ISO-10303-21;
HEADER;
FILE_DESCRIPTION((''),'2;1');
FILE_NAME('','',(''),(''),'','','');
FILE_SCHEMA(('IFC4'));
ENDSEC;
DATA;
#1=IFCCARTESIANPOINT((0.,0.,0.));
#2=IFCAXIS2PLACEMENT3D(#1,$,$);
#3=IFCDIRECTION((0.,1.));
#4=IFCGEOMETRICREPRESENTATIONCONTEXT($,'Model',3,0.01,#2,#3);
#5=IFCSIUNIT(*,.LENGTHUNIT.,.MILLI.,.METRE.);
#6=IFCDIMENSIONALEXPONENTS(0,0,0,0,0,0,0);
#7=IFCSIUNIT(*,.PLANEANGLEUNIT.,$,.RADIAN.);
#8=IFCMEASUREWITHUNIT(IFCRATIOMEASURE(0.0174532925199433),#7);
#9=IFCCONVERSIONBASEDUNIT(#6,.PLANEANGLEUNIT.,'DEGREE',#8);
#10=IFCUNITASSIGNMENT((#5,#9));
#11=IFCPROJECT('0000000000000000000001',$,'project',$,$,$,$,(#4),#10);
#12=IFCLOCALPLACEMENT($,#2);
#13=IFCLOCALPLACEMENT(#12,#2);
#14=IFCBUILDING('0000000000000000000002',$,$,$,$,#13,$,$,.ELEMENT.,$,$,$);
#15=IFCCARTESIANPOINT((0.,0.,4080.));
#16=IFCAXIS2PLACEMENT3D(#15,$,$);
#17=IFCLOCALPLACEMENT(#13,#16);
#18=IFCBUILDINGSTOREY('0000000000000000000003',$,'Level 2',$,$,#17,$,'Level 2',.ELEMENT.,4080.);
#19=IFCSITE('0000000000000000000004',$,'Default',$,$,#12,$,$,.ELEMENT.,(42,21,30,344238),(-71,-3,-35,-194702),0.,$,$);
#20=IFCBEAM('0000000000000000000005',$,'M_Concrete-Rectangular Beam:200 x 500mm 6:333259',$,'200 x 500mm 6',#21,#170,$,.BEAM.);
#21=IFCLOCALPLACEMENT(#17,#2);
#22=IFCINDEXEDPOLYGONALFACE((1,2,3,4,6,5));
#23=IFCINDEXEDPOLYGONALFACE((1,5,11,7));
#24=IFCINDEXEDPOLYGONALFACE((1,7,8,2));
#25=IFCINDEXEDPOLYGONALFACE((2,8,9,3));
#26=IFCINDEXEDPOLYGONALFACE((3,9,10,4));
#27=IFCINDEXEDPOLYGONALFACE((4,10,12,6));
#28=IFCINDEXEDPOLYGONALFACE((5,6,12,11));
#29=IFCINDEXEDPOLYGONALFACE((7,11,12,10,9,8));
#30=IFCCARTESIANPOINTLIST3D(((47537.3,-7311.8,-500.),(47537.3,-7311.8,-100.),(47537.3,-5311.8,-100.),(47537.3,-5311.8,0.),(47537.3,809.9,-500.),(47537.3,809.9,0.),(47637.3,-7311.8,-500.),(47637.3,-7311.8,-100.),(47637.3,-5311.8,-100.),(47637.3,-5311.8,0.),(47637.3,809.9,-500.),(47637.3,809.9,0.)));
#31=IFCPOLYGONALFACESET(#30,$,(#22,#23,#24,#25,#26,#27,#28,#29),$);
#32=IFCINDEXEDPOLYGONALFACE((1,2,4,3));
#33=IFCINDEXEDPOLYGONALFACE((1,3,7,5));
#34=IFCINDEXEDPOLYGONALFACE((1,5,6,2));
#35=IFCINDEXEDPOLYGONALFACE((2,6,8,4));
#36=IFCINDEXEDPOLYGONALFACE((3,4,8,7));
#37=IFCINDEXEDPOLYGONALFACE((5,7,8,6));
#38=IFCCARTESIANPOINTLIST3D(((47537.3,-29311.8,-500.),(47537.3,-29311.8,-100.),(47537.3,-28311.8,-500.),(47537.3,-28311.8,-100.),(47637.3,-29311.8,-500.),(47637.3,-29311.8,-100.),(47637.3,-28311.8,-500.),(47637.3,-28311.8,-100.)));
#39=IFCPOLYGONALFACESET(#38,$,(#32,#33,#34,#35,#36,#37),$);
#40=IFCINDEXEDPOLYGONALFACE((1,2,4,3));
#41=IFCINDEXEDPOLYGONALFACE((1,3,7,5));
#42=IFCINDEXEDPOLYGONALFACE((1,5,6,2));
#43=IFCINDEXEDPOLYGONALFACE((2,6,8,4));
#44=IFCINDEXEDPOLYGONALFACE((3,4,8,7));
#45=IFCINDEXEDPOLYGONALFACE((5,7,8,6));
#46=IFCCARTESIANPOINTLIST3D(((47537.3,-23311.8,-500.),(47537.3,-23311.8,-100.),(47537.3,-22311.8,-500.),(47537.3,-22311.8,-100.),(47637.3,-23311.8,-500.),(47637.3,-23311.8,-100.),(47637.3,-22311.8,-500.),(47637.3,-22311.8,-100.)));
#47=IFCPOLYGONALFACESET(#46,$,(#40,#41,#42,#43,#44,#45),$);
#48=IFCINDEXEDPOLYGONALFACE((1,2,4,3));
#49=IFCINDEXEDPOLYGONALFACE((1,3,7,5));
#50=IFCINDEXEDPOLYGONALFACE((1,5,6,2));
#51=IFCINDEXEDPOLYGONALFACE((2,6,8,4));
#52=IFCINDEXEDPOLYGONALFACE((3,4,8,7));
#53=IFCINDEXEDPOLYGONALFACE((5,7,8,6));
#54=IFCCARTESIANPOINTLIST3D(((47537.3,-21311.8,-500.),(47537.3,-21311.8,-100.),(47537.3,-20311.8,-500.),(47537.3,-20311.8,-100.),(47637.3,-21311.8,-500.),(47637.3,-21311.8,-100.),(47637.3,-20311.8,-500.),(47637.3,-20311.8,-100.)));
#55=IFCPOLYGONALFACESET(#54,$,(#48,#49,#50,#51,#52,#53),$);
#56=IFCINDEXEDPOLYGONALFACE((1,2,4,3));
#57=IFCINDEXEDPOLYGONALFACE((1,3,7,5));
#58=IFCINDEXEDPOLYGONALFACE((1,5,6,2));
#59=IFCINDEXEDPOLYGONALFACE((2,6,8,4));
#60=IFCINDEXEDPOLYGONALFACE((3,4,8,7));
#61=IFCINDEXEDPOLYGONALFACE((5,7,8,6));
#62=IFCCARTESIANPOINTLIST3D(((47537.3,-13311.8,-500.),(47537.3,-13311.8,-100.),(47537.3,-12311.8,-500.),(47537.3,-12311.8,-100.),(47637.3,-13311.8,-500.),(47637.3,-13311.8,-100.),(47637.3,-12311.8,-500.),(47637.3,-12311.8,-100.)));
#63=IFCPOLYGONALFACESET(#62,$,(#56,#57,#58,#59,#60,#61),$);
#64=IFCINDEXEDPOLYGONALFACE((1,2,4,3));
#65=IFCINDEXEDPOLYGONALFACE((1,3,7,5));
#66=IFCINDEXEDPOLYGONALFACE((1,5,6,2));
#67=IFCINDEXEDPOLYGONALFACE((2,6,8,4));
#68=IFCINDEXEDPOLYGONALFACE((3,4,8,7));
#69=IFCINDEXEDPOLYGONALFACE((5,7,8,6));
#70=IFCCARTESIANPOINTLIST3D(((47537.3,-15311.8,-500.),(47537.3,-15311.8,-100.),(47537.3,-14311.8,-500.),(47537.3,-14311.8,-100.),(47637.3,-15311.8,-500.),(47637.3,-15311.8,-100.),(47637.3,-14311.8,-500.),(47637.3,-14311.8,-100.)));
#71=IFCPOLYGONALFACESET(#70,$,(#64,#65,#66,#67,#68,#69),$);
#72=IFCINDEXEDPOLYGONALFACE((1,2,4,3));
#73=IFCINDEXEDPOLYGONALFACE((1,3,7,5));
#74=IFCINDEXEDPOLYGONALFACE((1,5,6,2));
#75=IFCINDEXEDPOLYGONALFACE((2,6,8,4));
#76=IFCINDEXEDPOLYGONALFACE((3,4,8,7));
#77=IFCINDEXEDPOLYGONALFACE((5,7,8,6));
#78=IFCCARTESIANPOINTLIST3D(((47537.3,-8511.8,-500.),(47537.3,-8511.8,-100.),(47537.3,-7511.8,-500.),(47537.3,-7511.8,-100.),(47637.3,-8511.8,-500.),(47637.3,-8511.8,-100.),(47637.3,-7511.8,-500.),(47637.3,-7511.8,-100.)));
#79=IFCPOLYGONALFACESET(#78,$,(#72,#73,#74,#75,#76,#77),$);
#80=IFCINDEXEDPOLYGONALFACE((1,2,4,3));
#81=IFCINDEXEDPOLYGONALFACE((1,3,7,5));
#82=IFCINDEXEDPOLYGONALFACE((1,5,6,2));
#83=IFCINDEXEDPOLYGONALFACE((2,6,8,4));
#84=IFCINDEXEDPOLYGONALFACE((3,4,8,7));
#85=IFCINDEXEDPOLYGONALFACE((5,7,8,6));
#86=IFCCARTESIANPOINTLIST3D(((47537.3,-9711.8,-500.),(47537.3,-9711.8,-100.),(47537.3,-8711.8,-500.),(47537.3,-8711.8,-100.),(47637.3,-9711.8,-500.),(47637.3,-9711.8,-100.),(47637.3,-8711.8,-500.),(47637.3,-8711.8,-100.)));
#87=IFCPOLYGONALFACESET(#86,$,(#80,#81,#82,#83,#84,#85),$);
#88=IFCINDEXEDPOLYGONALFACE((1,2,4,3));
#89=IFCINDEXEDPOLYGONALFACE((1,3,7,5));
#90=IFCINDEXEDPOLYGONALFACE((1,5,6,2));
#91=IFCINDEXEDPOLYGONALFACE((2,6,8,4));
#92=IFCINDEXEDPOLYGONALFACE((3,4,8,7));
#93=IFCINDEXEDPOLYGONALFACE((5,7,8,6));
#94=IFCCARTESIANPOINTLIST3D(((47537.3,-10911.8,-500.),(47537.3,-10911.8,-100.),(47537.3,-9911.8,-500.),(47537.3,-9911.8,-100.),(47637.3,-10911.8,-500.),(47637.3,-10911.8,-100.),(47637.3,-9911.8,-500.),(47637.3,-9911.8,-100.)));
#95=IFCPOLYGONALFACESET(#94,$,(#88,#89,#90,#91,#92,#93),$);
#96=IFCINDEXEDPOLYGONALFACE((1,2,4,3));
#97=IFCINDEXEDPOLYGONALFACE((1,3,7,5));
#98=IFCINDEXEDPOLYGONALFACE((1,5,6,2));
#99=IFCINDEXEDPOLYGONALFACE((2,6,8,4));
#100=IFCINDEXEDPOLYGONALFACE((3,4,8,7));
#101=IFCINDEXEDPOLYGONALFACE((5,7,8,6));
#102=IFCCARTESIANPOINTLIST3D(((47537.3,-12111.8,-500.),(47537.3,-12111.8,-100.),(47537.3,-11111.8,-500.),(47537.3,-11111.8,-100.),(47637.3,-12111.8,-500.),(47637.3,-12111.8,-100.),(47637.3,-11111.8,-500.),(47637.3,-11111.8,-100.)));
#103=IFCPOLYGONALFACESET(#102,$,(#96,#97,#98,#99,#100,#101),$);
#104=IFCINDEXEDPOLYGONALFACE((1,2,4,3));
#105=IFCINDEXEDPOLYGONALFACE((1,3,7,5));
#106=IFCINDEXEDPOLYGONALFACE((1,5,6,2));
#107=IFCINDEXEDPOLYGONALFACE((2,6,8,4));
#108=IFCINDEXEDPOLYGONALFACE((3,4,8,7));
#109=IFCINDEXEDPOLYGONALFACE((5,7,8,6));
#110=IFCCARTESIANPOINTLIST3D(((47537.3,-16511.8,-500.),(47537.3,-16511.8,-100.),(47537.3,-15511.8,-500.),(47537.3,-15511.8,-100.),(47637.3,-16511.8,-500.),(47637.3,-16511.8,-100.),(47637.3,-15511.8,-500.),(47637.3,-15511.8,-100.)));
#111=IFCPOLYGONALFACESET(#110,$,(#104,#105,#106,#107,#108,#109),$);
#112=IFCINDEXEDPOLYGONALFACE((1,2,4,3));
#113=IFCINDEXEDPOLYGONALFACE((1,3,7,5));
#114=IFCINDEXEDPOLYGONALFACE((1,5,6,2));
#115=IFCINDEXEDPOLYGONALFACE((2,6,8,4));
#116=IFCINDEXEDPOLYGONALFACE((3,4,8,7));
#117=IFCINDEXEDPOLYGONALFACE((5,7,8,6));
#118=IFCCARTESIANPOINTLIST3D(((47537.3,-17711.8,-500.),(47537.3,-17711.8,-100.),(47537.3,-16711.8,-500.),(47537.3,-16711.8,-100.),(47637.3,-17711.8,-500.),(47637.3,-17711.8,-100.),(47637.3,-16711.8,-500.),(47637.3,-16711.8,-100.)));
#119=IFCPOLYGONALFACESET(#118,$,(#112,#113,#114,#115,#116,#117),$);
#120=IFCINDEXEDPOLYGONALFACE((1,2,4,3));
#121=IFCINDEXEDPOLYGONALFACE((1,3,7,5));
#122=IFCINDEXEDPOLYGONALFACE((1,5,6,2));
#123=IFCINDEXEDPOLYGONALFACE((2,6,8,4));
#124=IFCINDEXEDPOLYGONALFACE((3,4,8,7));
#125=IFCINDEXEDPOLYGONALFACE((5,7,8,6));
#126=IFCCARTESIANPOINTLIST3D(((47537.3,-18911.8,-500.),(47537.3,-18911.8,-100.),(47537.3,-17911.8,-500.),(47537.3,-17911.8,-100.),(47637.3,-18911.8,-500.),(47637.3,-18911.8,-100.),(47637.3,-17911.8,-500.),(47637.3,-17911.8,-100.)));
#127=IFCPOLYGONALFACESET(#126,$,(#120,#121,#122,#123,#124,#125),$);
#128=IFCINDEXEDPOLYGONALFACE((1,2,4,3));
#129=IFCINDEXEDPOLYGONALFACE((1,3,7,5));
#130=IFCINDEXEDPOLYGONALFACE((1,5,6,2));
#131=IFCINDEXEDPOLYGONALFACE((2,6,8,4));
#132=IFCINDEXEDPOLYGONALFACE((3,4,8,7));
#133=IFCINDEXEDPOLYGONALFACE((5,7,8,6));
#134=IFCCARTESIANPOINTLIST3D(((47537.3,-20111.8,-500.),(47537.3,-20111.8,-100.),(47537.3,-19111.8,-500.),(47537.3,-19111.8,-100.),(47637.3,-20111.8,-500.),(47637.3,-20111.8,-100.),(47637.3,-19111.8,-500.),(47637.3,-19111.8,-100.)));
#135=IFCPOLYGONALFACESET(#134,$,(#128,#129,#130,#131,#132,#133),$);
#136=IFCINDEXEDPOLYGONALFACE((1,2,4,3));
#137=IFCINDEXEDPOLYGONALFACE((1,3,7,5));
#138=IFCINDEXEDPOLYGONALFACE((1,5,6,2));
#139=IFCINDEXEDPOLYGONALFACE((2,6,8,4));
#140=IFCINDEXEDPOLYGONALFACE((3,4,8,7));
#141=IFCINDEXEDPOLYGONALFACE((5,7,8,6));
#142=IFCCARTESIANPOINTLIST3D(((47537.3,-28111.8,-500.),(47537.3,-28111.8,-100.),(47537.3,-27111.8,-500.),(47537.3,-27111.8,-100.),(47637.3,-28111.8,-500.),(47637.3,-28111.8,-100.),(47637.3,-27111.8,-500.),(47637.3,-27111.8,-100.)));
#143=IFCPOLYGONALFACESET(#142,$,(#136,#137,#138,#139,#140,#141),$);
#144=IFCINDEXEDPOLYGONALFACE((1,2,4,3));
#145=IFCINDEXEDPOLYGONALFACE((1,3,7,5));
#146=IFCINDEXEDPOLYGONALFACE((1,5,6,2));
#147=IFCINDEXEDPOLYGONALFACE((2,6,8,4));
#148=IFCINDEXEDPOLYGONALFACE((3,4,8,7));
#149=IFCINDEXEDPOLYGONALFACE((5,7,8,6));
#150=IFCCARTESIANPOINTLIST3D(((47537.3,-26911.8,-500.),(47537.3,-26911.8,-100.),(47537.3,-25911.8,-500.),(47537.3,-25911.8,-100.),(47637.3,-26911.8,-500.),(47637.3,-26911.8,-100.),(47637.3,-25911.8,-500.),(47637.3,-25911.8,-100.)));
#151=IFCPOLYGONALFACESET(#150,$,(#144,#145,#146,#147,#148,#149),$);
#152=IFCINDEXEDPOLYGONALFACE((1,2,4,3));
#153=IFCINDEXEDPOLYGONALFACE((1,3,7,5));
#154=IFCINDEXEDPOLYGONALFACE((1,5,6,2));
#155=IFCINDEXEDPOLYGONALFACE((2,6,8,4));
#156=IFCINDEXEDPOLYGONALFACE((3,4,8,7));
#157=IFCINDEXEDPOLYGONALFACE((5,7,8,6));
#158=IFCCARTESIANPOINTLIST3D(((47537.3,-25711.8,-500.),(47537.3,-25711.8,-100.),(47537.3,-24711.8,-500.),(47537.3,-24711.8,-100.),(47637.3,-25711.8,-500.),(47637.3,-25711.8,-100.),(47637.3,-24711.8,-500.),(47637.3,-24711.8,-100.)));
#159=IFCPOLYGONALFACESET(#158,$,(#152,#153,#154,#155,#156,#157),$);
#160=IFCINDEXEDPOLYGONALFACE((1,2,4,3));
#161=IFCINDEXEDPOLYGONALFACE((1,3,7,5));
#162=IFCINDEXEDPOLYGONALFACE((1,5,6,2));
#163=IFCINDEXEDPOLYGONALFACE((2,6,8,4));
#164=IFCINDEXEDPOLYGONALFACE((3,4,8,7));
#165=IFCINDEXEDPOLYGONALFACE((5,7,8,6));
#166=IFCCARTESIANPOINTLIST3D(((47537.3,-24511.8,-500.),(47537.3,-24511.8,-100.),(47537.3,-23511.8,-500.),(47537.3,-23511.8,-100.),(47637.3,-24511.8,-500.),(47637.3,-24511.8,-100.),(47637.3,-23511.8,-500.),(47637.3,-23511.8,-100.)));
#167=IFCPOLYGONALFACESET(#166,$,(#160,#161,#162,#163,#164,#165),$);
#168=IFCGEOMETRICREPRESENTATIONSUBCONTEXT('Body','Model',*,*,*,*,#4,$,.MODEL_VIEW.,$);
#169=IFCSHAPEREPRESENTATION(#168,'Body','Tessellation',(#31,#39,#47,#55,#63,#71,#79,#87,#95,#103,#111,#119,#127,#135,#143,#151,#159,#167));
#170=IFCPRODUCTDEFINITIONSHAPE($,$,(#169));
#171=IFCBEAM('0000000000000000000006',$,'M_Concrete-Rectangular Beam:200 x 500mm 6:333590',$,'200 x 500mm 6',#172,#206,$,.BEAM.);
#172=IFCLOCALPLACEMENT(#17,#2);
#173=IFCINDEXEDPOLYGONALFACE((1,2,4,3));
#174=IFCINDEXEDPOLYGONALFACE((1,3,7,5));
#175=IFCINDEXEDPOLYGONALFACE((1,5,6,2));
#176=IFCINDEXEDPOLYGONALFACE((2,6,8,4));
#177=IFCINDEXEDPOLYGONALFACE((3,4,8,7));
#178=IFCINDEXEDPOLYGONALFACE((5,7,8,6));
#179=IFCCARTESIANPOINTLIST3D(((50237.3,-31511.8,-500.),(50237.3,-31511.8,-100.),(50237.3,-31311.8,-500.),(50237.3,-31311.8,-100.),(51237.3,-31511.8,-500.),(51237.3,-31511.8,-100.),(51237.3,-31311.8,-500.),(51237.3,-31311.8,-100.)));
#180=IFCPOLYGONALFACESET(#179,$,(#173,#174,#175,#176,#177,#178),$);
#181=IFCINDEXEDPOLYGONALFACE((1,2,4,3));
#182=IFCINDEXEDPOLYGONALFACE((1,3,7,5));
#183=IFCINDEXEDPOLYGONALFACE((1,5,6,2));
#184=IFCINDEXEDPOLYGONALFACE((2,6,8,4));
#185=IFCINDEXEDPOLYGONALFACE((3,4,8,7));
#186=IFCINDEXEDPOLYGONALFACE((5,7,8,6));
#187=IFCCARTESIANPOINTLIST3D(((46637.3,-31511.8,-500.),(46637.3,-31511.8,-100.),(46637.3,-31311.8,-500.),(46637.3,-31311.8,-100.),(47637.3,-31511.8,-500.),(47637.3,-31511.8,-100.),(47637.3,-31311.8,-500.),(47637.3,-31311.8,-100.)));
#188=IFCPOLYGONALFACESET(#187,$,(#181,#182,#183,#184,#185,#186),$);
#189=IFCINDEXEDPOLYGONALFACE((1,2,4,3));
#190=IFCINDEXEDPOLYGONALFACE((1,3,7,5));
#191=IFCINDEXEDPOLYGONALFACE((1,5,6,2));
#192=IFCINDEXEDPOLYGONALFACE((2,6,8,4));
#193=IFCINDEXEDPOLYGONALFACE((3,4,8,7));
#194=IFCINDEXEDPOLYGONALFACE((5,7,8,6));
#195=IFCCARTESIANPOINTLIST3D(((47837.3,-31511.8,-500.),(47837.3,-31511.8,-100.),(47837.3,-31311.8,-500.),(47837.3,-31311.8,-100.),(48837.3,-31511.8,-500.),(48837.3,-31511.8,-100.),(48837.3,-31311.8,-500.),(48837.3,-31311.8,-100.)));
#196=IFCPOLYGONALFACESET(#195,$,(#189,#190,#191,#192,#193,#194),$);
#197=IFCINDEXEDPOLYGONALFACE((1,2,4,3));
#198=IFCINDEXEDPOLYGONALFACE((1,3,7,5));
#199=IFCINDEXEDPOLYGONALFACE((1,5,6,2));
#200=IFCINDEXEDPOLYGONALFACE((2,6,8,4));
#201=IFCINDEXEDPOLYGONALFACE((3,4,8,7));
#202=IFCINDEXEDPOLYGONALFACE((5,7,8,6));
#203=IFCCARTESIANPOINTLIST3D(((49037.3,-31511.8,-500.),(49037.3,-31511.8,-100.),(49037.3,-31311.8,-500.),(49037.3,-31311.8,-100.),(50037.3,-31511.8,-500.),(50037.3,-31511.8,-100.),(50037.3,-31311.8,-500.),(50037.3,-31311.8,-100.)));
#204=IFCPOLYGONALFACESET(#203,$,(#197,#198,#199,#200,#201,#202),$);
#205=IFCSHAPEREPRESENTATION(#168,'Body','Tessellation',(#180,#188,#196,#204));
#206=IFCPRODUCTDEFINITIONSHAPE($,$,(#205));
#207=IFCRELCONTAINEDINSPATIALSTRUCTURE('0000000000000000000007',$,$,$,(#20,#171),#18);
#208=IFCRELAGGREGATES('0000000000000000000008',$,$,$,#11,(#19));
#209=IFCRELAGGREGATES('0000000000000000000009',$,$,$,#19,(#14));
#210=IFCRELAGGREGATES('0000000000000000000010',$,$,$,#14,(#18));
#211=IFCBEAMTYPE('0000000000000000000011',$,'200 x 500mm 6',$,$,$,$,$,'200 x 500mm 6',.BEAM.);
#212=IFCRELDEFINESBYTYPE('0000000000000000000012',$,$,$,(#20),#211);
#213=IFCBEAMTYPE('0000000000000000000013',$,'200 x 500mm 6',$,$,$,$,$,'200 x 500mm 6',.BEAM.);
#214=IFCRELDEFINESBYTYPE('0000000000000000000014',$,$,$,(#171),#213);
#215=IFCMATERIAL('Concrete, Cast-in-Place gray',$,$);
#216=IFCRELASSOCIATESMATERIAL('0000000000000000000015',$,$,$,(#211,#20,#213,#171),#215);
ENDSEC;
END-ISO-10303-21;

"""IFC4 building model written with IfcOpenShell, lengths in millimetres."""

from ifc_helpers import new_model, entity, si_unit, converted_unit, direction, frame, frame_2d, origin, origin_2d_with_axis, place, context, subcontext, project, spatial, polyline, rectangle, outline, extrude, source, transform, mapped, material, type_object, type_shapes, element, save


model = new_model("IFC4")

# Units and contexts
model_context = context("Model", 3, precision=0.01, world=origin(), true_north=direction((0.0, 1.0)))
body_context = subcontext(model_context, "Body", "Model", "MODEL_VIEW")
ifc_project = project(units=[si_unit("LENGTHUNIT", "METRE", prefix="MILLI"), converted_unit("PLANEANGLEUNIT", "DEGREE", entity("IfcRatioMeasure", 0.0174532925199433), si_unit("PLANEANGLEUNIT", "RADIAN"), dimensions=[0, 0, 0, 0, 0, 0, 0])], contexts=[model_context])

# Site, building, storey
site_placement = place(None, origin())
site = spatial("IfcSite", under=ifc_project, at=site_placement, Name="Default", CompositionType="ELEMENT", RefLatitude=(42, 21, 30, 344238), RefLongitude=(-71, -3, -35, -194702), RefElevation=0.0)
building_placement = place(site_placement, origin())
building = spatial("IfcBuilding", under=site, at=building_placement, CompositionType="ELEMENT")
storey_placement = place(building_placement, frame((0.0, 0.0, 4080.0)))
storey = spatial("IfcBuildingStorey", under=building, at=storey_placement, Name="Level 2", LongName="Level 2", CompositionType="ELEMENT", Elevation=4080.0)

# Beams
ifc_material_1 = material(Name="Concrete, Cast-in-Place gray")
beam_type_1 = type_object("IfcBeamType", Name="200 x 500mm 6", ElementType="200 x 500mm 6", PredefinedType="BEAM", material=ifc_material_1)
shared_shape_1 = source(origin(), body_context, "Body", "SweptSolid", [
    extrude(outline(polyline([(-4747.8, -200.0), (1373.9, -200.0), (1373.9, -100.0), (3373.9, -100.0), (3373.9, 300.0), (-4747.8, 300.0), (-4747.8, -200.0)])), frame((47537.3, -3937.9, 3880.0), z_axis=(1.0, 0.0, 0.0), x_axis=(0.0, -1.0, 0.0)), (0.0, 0.0, 1.0), 100.0),
    extrude(rectangle(XDim=1000.0, YDim=100.0, at=frame_2d((0.0, 0.0), x_axis=(1.0, 0.0))), frame((47587.3, -28811.8, 3580.0), z_axis=(0.0, 0.0, 1.0), x_axis=(0.0, 1.0, 0.0)), (0.0, 0.0, 1.0), 400.0),
    extrude(rectangle(XDim=1000.0, YDim=100.0, at=frame_2d((0.0, 0.0), x_axis=(1.0, 0.0))), frame((47587.3, -22811.8, 3580.0), z_axis=(0.0, 0.0, 1.0), x_axis=(0.0, -1.0, 0.0)), (0.0, 0.0, 1.0), 400.0),
    extrude(rectangle(XDim=1000.0, YDim=100.0, at=frame_2d((0.0, 0.0), x_axis=(1.0, 0.0))), frame((47587.3, -20811.8, 3580.0), z_axis=(0.0, 0.0, 1.0), x_axis=(0.0, 1.0, 0.0)), (0.0, 0.0, 1.0), 400.0),
    extrude(rectangle(XDim=100.0, YDim=1000.0, at=frame_2d((0.0, 0.0), x_axis=(1.0, 0.0))), frame((47587.3, -12811.8, 3580.0)), (0.0, 0.0, 1.0), 400.0),
    extrude(rectangle(XDim=1000.0, YDim=100.0, at=origin_2d_with_axis()), frame((47587.3, -14811.8, 3580.0), z_axis=(0.0, 0.0, 1.0), x_axis=(0.0, -1.0, 0.0)), (0.0, 0.0, 1.0), 400.0),
    extrude(rectangle(XDim=100.0, YDim=1000.0, at=origin_2d_with_axis()), frame((47587.3, -8011.8, 3580.0)), (0.0, 0.0, 1.0), 400.0),
    extrude(rectangle(XDim=100.0, YDim=1000.0, at=frame_2d((0.0, 0.0), x_axis=(1.0, 0.0))), frame((47587.3, -9211.8, 3580.0)), (0.0, 0.0, 1.0), 400.0),
    extrude(rectangle(XDim=100.0, YDim=1000.0, at=frame_2d((0.0, 0.0), x_axis=(1.0, 0.0))), frame((47587.3, -10411.8, 3580.0)), (0.0, 0.0, 1.0), 400.0),
    extrude(rectangle(XDim=100.0, YDim=1000.0, at=frame_2d((0.0, 0.0), x_axis=(1.0, 0.0))), frame((47587.3, -11611.8, 3580.0)), (0.0, 0.0, 1.0), 400.0),
    extrude(rectangle(XDim=1000.0, YDim=100.0, at=frame_2d((0.0, 0.0), x_axis=(1.0, 0.0))), frame((47587.3, -16011.8, 3580.0), z_axis=(0.0, 0.0, 1.0), x_axis=(0.0, -1.0, 0.0)), (0.0, 0.0, 1.0), 400.0),
    extrude(rectangle(XDim=1000.0, YDim=100.0, at=frame_2d((0.0, 0.0), x_axis=(1.0, 0.0))), frame((47587.3, -17211.8, 3580.0), z_axis=(0.0, 0.0, 1.0), x_axis=(0.0, -1.0, 0.0)), (0.0, 0.0, 1.0), 400.0),
    extrude(rectangle(XDim=1000.0, YDim=100.0, at=frame_2d((0.0, 0.0), x_axis=(1.0, 0.0))), frame((47587.3, -18411.8, 3580.0), z_axis=(0.0, 0.0, 1.0), x_axis=(0.0, -1.0, 0.0)), (0.0, 0.0, 1.0), 400.0),
    extrude(rectangle(XDim=1000.0, YDim=100.0, at=frame_2d((0.0, 0.0), x_axis=(1.0, 0.0))), frame((47587.3, -19611.8, 3580.0), z_axis=(0.0, 0.0, 1.0), x_axis=(0.0, -1.0, 0.0)), (0.0, 0.0, 1.0), 400.0),
    extrude(rectangle(XDim=1000.0, YDim=100.0, at=frame_2d((0.0, 0.0), x_axis=(1.0, 0.0))), frame((47587.3, -27611.8, 3580.0), z_axis=(0.0, 0.0, 1.0), x_axis=(0.0, 1.0, 0.0)), (0.0, 0.0, 1.0), 400.0),
    extrude(rectangle(XDim=1000.0, YDim=100.0, at=origin_2d_with_axis()), frame((47587.3, -26411.8, 3580.0), z_axis=(0.0, 0.0, 1.0), x_axis=(0.0, 1.0, 0.0)), (0.0, 0.0, 1.0), 400.0),
    extrude(rectangle(XDim=1000.0, YDim=100.0, at=frame_2d((0.0, 0.0), x_axis=(1.0, 0.0))), frame((47587.3, -25211.8, 3580.0), z_axis=(0.0, 0.0, 1.0), x_axis=(0.0, 1.0, 0.0)), (0.0, 0.0, 1.0), 400.0),
    extrude(rectangle(XDim=1000.0, YDim=100.0, at=frame_2d((0.0, 0.0), x_axis=(1.0, 0.0))), frame((47587.3, -24011.8, 3580.0), z_axis=(0.0, 0.0, 1.0), x_axis=(0.0, 1.0, 0.0)), (0.0, 0.0, 1.0), 400.0),
])
type_shapes(beam_type_1, [shared_shape_1])
beam_1_placement = place(storey_placement, frame((0.0, 0.0, -4080.0)))
element("IfcBeam", 1, at=beam_1_placement, inside=storey, type_object=beam_type_1, material=ifc_material_1, Name="M_Concrete-Rectangular Beam:200 x 500mm 6:333259", ObjectType="200 x 500mm 6", PredefinedType="BEAM", context=body_context, shape_type="MappedRepresentation", body=[
    mapped(shared_shape_1, transform((0.0, 0.0, 0.0), scale=1.0)),
])
beam_type_2 = type_object("IfcBeamType", Name="200 x 500mm 6", ElementType="200 x 500mm 6", PredefinedType="BEAM", material=ifc_material_1)
shared_shape_2 = source(origin(), body_context, "Body", "SweptSolid", [
    extrude(rectangle(XDim=1000.0, YDim=200.0, at=frame_2d((0.0, 0.0), x_axis=(1.0, 0.0))), frame((50737.3, -31411.8, 3580.0), z_axis=(0.0, 0.0, 1.0), x_axis=(-1.0, 0.0, 0.0)), (0.0, 0.0, 1.0), 400.0),
    extrude(rectangle(XDim=1000.0, YDim=200.0, at=frame_2d((0.0, 0.0), x_axis=(1.0, 0.0))), frame((47137.3, -31411.8, 3580.0)), (0.0, 0.0, 1.0), 400.0),
    extrude(rectangle(XDim=1000.0, YDim=200.0, at=frame_2d((0.0, 0.0), x_axis=(1.0, 0.0))), frame((48337.3, -31411.8, 3580.0)), (0.0, 0.0, 1.0), 400.0),
    extrude(rectangle(XDim=1000.0, YDim=200.0, at=frame_2d((0.0, 0.0), x_axis=(1.0, 0.0))), frame((49537.3, -31411.8, 3580.0)), (0.0, 0.0, 1.0), 400.0),
])
type_shapes(beam_type_2, [shared_shape_2])
beam_2_placement = place(storey_placement, frame((0.0, 0.0, -4080.0)))
element("IfcBeam", 2, at=beam_2_placement, inside=storey, type_object=beam_type_2, material=ifc_material_1, Name="M_Concrete-Rectangular Beam:200 x 500mm 6:333590", ObjectType="200 x 500mm 6", PredefinedType="BEAM", context=body_context, shape_type="MappedRepresentation", body=[
    mapped(shared_shape_2, transform((0.0, 0.0, 0.0), scale=1.0)),
])

save(model, "model.ifc")
